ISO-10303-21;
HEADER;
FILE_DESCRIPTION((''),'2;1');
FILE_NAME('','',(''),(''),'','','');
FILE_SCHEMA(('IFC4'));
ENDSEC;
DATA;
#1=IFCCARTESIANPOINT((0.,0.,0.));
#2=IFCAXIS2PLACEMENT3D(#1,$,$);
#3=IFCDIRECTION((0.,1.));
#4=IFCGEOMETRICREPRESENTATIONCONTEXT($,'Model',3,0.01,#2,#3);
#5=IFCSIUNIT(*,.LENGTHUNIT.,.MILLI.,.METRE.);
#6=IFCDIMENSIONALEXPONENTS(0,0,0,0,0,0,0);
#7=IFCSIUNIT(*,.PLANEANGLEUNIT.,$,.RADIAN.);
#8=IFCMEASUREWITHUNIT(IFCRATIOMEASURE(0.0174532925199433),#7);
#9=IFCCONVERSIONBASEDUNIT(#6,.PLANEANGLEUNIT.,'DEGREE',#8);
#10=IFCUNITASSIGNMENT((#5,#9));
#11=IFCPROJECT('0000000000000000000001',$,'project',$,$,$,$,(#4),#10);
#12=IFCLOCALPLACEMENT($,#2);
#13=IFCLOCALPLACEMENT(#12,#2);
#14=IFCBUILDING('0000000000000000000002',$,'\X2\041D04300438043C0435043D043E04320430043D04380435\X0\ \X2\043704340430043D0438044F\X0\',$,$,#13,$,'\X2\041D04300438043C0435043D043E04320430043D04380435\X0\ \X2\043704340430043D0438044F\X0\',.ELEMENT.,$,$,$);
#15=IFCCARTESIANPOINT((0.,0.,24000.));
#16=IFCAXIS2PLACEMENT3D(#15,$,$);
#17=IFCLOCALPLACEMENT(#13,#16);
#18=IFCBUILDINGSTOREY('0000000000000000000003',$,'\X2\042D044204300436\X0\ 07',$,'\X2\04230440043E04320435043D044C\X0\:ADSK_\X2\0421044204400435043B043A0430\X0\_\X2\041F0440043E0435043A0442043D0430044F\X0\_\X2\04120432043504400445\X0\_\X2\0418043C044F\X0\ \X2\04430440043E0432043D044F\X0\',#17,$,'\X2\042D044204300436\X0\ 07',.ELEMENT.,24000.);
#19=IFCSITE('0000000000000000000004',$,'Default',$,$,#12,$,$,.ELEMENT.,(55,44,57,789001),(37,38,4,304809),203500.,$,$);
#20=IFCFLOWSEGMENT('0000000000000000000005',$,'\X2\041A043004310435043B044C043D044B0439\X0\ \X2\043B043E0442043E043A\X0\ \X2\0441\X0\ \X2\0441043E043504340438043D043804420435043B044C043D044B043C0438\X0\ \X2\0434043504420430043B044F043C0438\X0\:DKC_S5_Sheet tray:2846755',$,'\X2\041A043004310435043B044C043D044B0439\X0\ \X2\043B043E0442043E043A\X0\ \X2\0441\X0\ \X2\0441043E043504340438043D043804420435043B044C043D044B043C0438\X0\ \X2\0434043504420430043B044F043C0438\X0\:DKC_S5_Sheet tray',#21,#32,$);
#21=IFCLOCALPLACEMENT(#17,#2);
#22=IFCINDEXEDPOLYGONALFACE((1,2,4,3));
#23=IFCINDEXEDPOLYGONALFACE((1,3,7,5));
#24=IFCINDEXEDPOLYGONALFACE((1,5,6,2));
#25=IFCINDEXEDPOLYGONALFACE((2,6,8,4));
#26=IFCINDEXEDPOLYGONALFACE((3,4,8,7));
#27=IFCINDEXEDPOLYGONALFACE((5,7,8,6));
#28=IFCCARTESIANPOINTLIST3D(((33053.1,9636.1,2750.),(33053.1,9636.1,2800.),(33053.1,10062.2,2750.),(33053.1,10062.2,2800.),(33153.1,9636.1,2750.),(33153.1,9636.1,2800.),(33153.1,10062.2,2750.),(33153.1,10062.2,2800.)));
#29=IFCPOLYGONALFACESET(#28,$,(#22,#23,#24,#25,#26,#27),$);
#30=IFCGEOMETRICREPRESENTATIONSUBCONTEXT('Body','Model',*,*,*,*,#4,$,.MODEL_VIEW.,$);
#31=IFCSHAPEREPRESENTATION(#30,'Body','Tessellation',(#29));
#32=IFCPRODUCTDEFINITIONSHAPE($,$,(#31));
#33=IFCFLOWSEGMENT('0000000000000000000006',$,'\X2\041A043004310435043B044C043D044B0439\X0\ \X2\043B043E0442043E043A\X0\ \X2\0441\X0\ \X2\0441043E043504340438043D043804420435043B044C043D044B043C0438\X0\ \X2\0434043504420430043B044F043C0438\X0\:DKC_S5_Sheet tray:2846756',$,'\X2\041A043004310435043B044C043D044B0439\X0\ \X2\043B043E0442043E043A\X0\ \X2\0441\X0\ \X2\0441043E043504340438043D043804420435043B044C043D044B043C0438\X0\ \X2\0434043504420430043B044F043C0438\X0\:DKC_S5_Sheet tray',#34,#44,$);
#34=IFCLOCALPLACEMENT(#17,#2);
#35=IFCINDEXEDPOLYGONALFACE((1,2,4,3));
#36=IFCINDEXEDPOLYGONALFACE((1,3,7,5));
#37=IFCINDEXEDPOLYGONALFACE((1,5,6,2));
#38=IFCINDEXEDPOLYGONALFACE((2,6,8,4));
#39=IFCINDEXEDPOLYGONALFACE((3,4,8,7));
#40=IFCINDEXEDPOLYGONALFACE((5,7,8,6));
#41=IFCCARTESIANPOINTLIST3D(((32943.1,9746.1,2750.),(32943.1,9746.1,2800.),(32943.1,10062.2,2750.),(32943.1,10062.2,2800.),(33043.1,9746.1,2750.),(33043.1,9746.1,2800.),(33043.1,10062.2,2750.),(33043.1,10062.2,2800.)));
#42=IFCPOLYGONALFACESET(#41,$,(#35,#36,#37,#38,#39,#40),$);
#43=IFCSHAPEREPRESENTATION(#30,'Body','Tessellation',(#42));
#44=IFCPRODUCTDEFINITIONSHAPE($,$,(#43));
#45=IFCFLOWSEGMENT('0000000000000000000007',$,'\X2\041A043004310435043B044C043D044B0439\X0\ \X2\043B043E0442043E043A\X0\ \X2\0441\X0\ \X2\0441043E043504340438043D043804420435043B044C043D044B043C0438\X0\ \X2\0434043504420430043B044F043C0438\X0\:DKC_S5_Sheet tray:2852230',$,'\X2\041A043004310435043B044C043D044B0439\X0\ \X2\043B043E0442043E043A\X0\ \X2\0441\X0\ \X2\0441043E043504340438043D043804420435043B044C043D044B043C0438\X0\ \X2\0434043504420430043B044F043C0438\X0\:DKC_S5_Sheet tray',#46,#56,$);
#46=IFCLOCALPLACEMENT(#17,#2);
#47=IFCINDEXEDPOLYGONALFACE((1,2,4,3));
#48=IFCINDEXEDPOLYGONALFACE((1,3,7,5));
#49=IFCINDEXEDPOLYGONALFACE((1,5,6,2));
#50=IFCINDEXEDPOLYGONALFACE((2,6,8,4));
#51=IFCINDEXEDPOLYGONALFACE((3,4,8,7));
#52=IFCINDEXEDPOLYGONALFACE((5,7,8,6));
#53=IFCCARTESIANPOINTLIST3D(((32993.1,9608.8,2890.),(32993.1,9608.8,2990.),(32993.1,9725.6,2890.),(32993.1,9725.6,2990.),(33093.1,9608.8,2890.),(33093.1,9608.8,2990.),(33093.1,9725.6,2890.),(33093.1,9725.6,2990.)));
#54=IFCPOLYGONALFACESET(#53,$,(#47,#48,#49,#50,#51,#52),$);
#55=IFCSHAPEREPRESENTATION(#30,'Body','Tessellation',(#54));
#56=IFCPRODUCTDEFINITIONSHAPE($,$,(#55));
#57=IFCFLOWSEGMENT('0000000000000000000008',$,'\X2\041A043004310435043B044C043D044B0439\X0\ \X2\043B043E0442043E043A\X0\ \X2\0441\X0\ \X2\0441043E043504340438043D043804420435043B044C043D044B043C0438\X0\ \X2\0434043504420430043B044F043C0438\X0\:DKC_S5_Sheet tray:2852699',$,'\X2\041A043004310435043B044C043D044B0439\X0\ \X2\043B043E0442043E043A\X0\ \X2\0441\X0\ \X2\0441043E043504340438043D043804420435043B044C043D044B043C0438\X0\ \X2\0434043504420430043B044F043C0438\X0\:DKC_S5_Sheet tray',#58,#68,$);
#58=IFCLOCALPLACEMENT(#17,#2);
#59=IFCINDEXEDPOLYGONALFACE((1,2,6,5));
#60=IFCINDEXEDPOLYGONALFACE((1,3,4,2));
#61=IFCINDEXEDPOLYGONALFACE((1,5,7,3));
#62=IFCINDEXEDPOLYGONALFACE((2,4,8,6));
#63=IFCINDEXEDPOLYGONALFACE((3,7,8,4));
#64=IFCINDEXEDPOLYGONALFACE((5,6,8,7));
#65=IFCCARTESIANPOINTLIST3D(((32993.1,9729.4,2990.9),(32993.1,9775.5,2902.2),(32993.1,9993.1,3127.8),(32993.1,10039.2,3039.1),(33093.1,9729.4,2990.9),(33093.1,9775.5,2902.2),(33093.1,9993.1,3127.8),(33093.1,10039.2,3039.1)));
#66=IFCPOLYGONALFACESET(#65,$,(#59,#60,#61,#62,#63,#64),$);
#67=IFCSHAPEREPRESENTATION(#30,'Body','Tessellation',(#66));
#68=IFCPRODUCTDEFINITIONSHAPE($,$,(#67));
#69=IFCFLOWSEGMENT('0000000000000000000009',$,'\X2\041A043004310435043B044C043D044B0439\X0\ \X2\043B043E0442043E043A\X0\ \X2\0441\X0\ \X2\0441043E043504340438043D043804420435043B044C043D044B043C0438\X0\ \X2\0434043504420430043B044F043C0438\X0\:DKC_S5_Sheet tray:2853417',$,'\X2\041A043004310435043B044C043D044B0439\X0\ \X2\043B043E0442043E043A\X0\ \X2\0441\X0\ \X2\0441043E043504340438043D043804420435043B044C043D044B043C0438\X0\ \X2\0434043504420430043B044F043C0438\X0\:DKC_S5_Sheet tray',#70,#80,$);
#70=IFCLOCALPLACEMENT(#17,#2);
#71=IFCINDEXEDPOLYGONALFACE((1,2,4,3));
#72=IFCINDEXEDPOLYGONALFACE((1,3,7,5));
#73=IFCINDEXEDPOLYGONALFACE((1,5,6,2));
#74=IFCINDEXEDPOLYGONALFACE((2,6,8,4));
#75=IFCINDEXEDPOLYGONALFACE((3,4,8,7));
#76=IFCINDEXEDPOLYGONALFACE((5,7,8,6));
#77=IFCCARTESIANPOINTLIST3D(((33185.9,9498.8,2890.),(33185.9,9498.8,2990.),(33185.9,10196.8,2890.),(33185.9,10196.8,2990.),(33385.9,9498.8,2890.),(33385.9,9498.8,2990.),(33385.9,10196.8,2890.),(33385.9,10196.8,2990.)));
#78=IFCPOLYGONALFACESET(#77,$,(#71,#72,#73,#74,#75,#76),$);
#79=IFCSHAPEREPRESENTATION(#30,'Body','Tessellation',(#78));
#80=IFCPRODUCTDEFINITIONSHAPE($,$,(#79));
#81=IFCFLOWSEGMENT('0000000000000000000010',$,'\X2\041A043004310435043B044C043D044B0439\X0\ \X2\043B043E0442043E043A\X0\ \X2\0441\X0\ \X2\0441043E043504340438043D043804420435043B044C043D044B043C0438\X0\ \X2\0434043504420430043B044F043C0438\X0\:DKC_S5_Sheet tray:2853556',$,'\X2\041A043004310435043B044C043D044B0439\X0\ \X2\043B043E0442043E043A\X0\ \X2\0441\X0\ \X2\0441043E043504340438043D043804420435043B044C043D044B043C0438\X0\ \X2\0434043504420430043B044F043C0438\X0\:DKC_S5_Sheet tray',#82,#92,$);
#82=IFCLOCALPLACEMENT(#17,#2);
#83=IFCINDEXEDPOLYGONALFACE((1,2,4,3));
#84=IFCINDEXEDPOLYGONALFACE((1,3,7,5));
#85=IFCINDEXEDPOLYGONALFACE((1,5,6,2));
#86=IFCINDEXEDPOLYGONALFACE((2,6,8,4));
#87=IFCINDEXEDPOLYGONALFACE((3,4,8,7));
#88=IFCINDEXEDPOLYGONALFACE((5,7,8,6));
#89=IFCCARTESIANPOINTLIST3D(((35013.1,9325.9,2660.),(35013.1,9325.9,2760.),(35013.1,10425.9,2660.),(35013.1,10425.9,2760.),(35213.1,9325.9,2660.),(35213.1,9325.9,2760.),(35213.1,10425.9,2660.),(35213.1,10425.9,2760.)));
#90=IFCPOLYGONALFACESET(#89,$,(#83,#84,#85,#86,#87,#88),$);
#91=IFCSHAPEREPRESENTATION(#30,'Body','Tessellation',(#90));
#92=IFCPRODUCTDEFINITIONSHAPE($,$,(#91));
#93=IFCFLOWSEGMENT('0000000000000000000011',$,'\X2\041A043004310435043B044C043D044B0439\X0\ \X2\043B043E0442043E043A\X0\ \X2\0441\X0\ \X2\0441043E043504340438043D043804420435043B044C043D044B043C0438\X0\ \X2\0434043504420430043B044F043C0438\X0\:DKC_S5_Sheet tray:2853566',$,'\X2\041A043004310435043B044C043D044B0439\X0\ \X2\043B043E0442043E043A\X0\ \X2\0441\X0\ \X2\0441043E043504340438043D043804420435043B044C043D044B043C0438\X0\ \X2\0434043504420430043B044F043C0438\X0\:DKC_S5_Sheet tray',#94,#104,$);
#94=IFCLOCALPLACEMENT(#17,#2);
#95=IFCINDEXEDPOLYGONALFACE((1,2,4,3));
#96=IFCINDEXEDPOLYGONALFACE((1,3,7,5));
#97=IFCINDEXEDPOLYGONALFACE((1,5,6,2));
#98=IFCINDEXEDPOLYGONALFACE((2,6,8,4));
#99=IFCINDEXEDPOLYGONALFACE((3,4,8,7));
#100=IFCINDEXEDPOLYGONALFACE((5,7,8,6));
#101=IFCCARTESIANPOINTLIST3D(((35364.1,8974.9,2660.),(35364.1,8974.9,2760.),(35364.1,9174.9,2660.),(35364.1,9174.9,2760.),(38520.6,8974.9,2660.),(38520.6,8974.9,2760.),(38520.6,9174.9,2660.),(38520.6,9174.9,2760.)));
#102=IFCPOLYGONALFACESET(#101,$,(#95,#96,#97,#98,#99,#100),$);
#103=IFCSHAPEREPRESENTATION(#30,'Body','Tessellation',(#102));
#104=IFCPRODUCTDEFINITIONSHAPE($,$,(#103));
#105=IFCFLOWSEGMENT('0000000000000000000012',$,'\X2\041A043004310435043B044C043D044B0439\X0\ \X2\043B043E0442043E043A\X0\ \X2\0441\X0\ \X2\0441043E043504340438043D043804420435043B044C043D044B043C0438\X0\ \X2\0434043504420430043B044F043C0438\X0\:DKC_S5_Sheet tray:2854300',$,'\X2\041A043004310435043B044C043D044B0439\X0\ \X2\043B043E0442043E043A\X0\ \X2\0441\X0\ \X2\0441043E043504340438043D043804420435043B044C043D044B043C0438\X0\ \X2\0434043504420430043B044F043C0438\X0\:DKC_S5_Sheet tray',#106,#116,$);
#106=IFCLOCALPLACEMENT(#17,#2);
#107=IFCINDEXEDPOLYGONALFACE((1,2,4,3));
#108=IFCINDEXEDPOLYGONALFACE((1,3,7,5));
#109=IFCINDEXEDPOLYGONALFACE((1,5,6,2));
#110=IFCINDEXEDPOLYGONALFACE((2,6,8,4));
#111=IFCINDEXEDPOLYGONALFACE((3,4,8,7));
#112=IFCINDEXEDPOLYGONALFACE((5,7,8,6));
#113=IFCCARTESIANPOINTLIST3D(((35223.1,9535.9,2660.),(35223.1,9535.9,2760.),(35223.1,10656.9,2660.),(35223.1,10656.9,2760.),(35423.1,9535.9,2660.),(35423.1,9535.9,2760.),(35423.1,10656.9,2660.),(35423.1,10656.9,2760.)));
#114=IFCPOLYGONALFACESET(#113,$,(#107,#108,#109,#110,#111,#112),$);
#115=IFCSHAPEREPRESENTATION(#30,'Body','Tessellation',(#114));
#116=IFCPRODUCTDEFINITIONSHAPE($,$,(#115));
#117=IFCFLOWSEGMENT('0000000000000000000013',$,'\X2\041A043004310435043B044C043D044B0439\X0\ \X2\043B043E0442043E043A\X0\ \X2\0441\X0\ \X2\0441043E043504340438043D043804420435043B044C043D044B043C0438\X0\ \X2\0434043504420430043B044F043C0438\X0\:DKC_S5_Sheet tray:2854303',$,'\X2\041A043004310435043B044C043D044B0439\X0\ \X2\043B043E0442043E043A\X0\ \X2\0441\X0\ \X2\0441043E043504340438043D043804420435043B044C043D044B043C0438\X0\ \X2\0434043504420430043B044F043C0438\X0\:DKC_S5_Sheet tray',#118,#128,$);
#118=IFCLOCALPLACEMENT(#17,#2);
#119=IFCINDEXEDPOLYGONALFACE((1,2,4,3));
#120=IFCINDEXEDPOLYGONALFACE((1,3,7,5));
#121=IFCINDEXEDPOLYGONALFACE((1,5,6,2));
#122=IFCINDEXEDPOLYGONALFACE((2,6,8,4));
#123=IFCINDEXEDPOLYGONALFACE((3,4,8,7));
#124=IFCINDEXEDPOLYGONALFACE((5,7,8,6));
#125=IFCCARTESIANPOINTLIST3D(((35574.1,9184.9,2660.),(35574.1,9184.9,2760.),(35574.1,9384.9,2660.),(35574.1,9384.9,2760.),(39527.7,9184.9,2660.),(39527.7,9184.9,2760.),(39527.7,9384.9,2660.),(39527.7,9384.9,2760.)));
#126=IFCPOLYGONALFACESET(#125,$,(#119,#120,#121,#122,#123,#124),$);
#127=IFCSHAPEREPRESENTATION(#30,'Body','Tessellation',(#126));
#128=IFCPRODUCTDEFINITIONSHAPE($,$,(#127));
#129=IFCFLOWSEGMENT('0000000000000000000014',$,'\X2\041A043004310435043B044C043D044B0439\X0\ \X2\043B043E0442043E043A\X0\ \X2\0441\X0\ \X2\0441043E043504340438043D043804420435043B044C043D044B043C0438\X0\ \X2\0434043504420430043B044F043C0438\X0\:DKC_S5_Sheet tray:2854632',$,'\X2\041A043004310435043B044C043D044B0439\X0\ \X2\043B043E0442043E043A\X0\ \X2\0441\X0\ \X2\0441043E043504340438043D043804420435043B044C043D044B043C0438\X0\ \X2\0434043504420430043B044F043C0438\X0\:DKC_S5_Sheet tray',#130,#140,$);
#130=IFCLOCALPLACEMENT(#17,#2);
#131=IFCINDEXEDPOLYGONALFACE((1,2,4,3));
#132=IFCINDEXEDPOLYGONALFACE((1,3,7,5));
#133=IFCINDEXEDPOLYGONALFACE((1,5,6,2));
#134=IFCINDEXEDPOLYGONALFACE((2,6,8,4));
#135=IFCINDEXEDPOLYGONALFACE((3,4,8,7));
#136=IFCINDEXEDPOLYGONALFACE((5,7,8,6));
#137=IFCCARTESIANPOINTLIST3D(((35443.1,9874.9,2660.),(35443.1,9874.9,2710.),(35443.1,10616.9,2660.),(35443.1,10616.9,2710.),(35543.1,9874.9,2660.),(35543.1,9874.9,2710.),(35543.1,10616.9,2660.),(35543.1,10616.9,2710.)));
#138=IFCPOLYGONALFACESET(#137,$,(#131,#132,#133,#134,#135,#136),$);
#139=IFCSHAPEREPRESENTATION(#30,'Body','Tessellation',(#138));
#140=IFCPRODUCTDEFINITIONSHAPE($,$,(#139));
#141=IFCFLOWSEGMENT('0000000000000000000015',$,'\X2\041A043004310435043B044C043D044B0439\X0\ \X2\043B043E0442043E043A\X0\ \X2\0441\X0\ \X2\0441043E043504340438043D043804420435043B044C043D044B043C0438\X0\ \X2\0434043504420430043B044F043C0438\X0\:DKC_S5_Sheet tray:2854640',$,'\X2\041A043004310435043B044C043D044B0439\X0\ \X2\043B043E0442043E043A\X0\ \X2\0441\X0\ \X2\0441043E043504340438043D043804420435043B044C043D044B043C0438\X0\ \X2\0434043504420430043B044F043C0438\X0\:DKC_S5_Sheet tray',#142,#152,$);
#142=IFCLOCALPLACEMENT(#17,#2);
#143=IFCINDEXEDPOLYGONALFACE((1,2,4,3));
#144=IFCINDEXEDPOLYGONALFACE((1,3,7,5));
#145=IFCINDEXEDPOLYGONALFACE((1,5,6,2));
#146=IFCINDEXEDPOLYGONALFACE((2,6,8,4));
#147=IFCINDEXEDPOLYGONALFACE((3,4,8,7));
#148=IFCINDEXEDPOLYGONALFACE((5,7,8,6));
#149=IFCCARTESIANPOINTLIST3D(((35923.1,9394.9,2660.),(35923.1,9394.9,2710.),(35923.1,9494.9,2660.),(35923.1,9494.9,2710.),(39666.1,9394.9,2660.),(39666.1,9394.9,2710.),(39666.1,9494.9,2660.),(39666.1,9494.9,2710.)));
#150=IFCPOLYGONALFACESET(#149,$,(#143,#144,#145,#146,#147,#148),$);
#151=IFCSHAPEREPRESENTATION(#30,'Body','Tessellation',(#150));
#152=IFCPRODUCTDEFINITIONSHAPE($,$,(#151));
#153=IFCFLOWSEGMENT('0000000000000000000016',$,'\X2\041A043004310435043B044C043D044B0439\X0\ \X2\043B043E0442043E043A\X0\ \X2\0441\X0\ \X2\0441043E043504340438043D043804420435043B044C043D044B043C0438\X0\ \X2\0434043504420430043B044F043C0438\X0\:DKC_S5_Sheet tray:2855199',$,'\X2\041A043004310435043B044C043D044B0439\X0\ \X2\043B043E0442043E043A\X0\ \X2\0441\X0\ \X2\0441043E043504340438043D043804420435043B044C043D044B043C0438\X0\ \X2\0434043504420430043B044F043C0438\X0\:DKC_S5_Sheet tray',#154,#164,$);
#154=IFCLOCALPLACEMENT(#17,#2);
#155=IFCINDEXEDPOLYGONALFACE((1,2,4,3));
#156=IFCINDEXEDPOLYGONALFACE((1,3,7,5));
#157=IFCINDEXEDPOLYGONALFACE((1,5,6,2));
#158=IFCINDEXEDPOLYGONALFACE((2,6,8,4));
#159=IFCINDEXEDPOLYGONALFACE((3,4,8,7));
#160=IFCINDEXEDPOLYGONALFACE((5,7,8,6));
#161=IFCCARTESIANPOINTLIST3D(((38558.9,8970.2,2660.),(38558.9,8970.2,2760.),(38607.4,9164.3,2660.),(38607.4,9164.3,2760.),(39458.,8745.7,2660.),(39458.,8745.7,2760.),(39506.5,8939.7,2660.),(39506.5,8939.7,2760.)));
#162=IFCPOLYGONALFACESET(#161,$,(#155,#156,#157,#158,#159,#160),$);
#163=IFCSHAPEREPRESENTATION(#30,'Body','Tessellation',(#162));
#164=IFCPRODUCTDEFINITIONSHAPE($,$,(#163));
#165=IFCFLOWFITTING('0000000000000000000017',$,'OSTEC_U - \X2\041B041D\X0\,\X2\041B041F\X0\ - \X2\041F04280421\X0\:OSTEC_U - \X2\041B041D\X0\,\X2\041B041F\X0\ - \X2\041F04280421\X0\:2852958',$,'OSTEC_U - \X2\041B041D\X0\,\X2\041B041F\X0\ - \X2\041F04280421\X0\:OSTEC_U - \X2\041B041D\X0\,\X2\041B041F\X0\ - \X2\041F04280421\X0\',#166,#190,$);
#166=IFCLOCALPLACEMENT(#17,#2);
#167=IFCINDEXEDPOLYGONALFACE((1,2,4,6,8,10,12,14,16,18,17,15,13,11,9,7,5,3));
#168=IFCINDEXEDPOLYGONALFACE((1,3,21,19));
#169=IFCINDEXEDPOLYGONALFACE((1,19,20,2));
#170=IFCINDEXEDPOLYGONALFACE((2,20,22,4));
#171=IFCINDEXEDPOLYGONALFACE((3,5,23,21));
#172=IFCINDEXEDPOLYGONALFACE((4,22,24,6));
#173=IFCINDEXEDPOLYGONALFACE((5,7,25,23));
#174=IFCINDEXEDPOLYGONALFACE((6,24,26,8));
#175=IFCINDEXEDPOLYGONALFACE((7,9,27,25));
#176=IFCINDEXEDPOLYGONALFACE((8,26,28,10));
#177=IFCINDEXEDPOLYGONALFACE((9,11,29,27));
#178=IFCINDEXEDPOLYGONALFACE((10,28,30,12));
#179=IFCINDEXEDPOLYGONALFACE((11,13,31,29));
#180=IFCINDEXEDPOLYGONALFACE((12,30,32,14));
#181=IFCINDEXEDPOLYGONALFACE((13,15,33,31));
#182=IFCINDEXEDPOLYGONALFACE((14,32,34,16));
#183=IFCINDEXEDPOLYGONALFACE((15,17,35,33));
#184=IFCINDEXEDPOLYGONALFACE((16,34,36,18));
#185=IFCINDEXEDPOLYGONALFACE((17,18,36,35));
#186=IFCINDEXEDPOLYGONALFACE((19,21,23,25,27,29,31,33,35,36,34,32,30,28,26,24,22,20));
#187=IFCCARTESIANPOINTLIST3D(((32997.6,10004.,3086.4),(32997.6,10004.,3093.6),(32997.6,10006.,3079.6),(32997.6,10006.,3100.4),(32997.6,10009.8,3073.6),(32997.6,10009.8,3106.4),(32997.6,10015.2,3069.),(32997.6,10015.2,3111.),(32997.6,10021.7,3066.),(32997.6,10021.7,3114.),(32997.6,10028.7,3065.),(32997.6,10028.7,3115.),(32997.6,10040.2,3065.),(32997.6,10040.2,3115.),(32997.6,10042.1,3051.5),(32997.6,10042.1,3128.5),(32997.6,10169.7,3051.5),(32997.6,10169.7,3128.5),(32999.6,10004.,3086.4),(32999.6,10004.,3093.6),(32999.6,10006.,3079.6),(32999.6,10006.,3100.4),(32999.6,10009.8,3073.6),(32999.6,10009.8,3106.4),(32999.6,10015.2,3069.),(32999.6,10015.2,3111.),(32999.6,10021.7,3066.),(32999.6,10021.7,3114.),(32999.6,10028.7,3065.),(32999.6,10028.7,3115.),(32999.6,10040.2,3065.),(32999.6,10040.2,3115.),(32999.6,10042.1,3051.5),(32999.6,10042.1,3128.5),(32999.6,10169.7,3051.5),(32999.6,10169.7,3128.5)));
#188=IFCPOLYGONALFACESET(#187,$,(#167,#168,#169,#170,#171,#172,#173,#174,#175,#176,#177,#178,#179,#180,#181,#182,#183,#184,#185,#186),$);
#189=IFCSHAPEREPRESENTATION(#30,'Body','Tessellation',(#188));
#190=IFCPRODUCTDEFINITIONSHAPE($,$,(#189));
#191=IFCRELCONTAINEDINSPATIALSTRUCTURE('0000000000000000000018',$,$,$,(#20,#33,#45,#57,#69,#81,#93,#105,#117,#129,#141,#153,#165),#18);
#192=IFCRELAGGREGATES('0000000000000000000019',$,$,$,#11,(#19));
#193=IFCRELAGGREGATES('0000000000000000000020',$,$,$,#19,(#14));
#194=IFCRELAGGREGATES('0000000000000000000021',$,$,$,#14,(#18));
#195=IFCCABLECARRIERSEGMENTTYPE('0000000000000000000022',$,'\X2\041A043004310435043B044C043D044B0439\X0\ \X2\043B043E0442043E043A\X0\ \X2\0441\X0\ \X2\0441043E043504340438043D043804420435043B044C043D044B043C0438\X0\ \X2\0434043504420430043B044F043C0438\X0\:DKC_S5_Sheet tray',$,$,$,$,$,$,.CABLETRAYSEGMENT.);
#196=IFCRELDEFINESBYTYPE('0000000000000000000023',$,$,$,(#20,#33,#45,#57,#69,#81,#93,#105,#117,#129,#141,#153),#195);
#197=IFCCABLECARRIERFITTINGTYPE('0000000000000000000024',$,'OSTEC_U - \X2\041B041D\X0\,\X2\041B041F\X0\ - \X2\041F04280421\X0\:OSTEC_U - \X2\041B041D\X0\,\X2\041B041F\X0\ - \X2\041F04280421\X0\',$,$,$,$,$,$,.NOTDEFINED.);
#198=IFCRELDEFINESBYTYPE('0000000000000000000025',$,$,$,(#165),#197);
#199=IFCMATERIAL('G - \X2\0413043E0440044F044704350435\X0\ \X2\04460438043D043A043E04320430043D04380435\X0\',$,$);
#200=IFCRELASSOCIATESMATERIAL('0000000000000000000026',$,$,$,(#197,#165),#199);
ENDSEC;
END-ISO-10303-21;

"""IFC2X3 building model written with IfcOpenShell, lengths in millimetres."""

from ifc_helpers import new_model, entity, si_unit, converted_unit, direction, frame, frame_2d, origin, origin_2d_with_axis, place, context, subcontext, project, spatial, polyline, circle_curve, parameter, trimmed, segment, composite_curve, rectangle, outline, extrude, source, transform, mapped, material, type_object, type_shapes, element, save


model = new_model("IFC2X3")

# Units and contexts
model_context = context("Model", 3, precision=0.01, world=origin(), true_north=direction((0.0, 1.0)))
body_context = subcontext(model_context, "Body", "Model", "MODEL_VIEW")
ifc_project = project(units=[si_unit("LENGTHUNIT", "METRE", prefix="MILLI"), converted_unit("PLANEANGLEUNIT", "DEGREE", entity("IfcRatioMeasure", 0.0174532925199433), si_unit("PLANEANGLEUNIT", "RADIAN"), dimensions=[0, 0, 0, 0, 0, 0, 0])], contexts=[model_context])

# Site, building, storey
site_placement = place(None, origin())
site = spatial("IfcSite", under=ifc_project, at=site_placement, Name="Default", CompositionType="ELEMENT", RefLatitude=(55, 44, 57, 789001), RefLongitude=(37, 38, 4, 304809), RefElevation=203500.0)
building_placement = place(site_placement, origin())
building = spatial("IfcBuilding", under=site, at=building_placement, Name="Наименование здания", LongName="Наименование здания", CompositionType="ELEMENT")
storey_placement = place(building_placement, frame((0.0, 0.0, 24000.0)))
storey = spatial("IfcBuildingStorey", under=building, at=storey_placement, Name="Этаж 07", ObjectType="Уровень:ADSK_Стрелка_Проектная_Вверх_Имя уровня", LongName="Этаж 07", CompositionType="ELEMENT", Elevation=24000.0)

# Flow segments
cable_carrier_segment_type = type_object("IfcCableCarrierSegmentType", Name="Кабельный лоток с соединительными деталями:DKC_S5_Sheet tray", PredefinedType="CABLETRAYSEGMENT")
flow_segment_1_placement = place(storey_placement, frame((33053.1, 9636.1, 2750.0)))
element("IfcFlowSegment", 1, at=flow_segment_1_placement, inside=storey, type_object=cable_carrier_segment_type, Name="Кабельный лоток с соединительными деталями:DKC_S5_Sheet tray:2846755", ObjectType="Кабельный лоток с соединительными деталями:DKC_S5_Sheet tray", context=body_context, shape_type="SweptSolid", body=[
    extrude(rectangle(XDim=426.1, YDim=100.0, at=origin_2d_with_axis()), frame((50.0, 213.0, 0.0), z_axis=(0.0, 0.0, 1.0), x_axis=(0.0, -1.0, 0.0)), (0.0, 0.0, 1.0), 50.0),
])
flow_segment_2_placement = place(storey_placement, frame((32943.1, 9746.1, 2750.0)))
element("IfcFlowSegment", 2, at=flow_segment_2_placement, inside=storey, type_object=cable_carrier_segment_type, Name="Кабельный лоток с соединительными деталями:DKC_S5_Sheet tray:2846756", ObjectType="Кабельный лоток с соединительными деталями:DKC_S5_Sheet tray", context=body_context, shape_type="SweptSolid", body=[
    extrude(rectangle(XDim=316.1, YDim=100.0, at=origin_2d_with_axis()), frame((50.0, 158.0, 0.0), z_axis=(0.0, 0.0, 1.0), x_axis=(0.0, 1.0, 0.0)), (0.0, 0.0, 1.0), 50.0),
])
flow_segment_3_placement = place(storey_placement, frame((32993.1, 9608.8, 2890.0)))
element("IfcFlowSegment", 3, at=flow_segment_3_placement, inside=storey, type_object=cable_carrier_segment_type, Name="Кабельный лоток с соединительными деталями:DKC_S5_Sheet tray:2852230", ObjectType="Кабельный лоток с соединительными деталями:DKC_S5_Sheet tray", context=body_context, shape_type="SweptSolid", body=[
    extrude(rectangle(XDim=116.8, YDim=100.0, at=origin_2d_with_axis()), frame((50.0, 58.4, 0.0), z_axis=(0.0, 0.0, 1.0), x_axis=(0.0, 1.0, 0.0)), (0.0, 0.0, 1.0), 100.0),
])
flow_segment_4_placement = place(storey_placement, frame((32993.1, 9729.4, 2902.2)))
element("IfcFlowSegment", 4, at=flow_segment_4_placement, inside=storey, type_object=cable_carrier_segment_type, Name="Кабельный лоток с соединительными деталями:DKC_S5_Sheet tray:2852699", ObjectType="Кабельный лоток с соединительными деталями:DKC_S5_Sheet tray", context=body_context, shape_type="SweptSolid", body=[
    extrude(rectangle(XDim=100.0, YDim=100.0, at=origin_2d_with_axis()), frame((50.0, 23.0, 44.4), z_axis=(0.0, 0.887491, 0.460826), x_axis=(0.0, -0.460826, 0.887491)), (0.0, 0.0, 1.0), 297.1),
])
flow_segment_5_placement = place(storey_placement, frame((33185.9, 9498.8, 2890.0)))
element("IfcFlowSegment", 5, at=flow_segment_5_placement, inside=storey, type_object=cable_carrier_segment_type, Name="Кабельный лоток с соединительными деталями:DKC_S5_Sheet tray:2853417", ObjectType="Кабельный лоток с соединительными деталями:DKC_S5_Sheet tray", context=body_context, shape_type="SweptSolid", body=[
    extrude(rectangle(XDim=698.0, YDim=200.0, at=origin_2d_with_axis()), frame((100.0, 349.0, 0.0), z_axis=(0.0, 0.0, 1.0), x_axis=(0.0, 1.0, 0.0)), (0.0, 0.0, 1.0), 100.0),
])
flow_segment_6_placement = place(storey_placement, frame((35013.1, 9325.9, 2660.0)))
element("IfcFlowSegment", 6, at=flow_segment_6_placement, inside=storey, type_object=cable_carrier_segment_type, Name="Кабельный лоток с соединительными деталями:DKC_S5_Sheet tray:2853556", ObjectType="Кабельный лоток с соединительными деталями:DKC_S5_Sheet tray", context=body_context, shape_type="SweptSolid", body=[
    extrude(rectangle(XDim=1100.0, YDim=200.0, at=origin_2d_with_axis()), frame((100.0, 550.0, 0.0), z_axis=(0.0, 0.0, 1.0), x_axis=(0.0, -1.0, 0.0)), (0.0, 0.0, 1.0), 100.0),
])
flow_segment_7_placement = place(storey_placement, frame((35364.1, 8974.9, 2660.0)))
element("IfcFlowSegment", 7, at=flow_segment_7_placement, inside=storey, type_object=cable_carrier_segment_type, Name="Кабельный лоток с соединительными деталями:DKC_S5_Sheet tray:2853566", ObjectType="Кабельный лоток с соединительными деталями:DKC_S5_Sheet tray", context=body_context, shape_type="SweptSolid", body=[
    extrude(rectangle(XDim=3156.5, YDim=200.0, at=origin_2d_with_axis()), frame((1578.3, 100.0, 0.0)), (0.0, 0.0, 1.0), 100.0),
])
flow_segment_8_placement = place(storey_placement, frame((35223.1, 9535.9, 2660.0)))
element("IfcFlowSegment", 8, at=flow_segment_8_placement, inside=storey, type_object=cable_carrier_segment_type, Name="Кабельный лоток с соединительными деталями:DKC_S5_Sheet tray:2854300", ObjectType="Кабельный лоток с соединительными деталями:DKC_S5_Sheet tray", context=body_context, shape_type="SweptSolid", body=[
    extrude(rectangle(XDim=1121.0, YDim=200.0, at=origin_2d_with_axis()), frame((100.0, 560.5, 0.0), z_axis=(0.0, 0.0, 1.0), x_axis=(0.0, -1.0, 0.0)), (0.0, 0.0, 1.0), 100.0),
])
flow_segment_9_placement = place(storey_placement, frame((35574.1, 9184.9, 2660.0)))
element("IfcFlowSegment", 9, at=flow_segment_9_placement, inside=storey, type_object=cable_carrier_segment_type, Name="Кабельный лоток с соединительными деталями:DKC_S5_Sheet tray:2854303", ObjectType="Кабельный лоток с соединительными деталями:DKC_S5_Sheet tray", context=body_context, shape_type="SweptSolid", body=[
    extrude(rectangle(XDim=3953.6, YDim=200.0, at=origin_2d_with_axis()), frame((1976.8, 100.0, 0.0)), (0.0, 0.0, 1.0), 100.0),
])
flow_segment_10_placement = place(storey_placement, frame((35443.1, 9874.9, 2660.0)))
element("IfcFlowSegment", 10, at=flow_segment_10_placement, inside=storey, type_object=cable_carrier_segment_type, Name="Кабельный лоток с соединительными деталями:DKC_S5_Sheet tray:2854632", ObjectType="Кабельный лоток с соединительными деталями:DKC_S5_Sheet tray", context=body_context, shape_type="SweptSolid", body=[
    extrude(rectangle(XDim=742.0, YDim=100.0, at=origin_2d_with_axis()), frame((50.0, 371.0, 0.0), z_axis=(0.0, 0.0, 1.0), x_axis=(0.0, -1.0, 0.0)), (0.0, 0.0, 1.0), 50.0),
])
flow_segment_11_placement = place(storey_placement, frame((35923.1, 9394.9, 2660.0)))
element("IfcFlowSegment", 11, at=flow_segment_11_placement, inside=storey, type_object=cable_carrier_segment_type, Name="Кабельный лоток с соединительными деталями:DKC_S5_Sheet tray:2854640", ObjectType="Кабельный лоток с соединительными деталями:DKC_S5_Sheet tray", context=body_context, shape_type="SweptSolid", body=[
    extrude(rectangle(XDim=3743.0, YDim=100.0, at=origin_2d_with_axis()), frame((1871.5, 50.0, 0.0)), (0.0, 0.0, 1.0), 50.0),
])
flow_segment_12_placement = place(storey_placement, frame((38558.9, 8745.7, 2660.0)))
element("IfcFlowSegment", 12, at=flow_segment_12_placement, inside=storey, type_object=cable_carrier_segment_type, Name="Кабельный лоток с соединительными деталями:DKC_S5_Sheet tray:2855199", ObjectType="Кабельный лоток с соединительными деталями:DKC_S5_Sheet tray", context=body_context, shape_type="SweptSolid", body=[
    extrude(rectangle(XDim=926.7, YDim=200.0, at=origin_2d_with_axis()), frame((473.8, 209.3, 0.0), z_axis=(0.0, 0.0, 1.0), x_axis=(-0.970197, 0.242319, 0.0)), (0.0, 0.0, 1.0), 100.0),
])

# Flow fitting
ifc_material_1 = material(Name="G - Горячее цинкование")
cable_carrier_fitting_type_1 = type_object("IfcCableCarrierFittingType", Name="OSTEC_U - ЛН,ЛП - ПШС:OSTEC_U - ЛН,ЛП - ПШС", PredefinedType="NOTDEFINED", material=ifc_material_1)
shared_shape_1 = source(origin(), body_context, "Body", "SweptSolid", [
    extrude(outline(composite_curve([segment(trimmed(circle_curve(frame_2d((-41.5, 0.0), x_axis=(1.0, 0.0)), 25.0), [parameter(90.0)], [parameter(270.0)], True, "PARAMETER"), True, "CONTINUOUS"), segment(polyline([(-41.5, -25.0), (-30.0, -25.0)]), True, "CONTINUOUS"), segment(polyline([(-30.0, -25.0), (-28.1, -38.5)]), True, "CONTINUOUS"), segment(polyline([(-28.1, -38.5), (99.5, -38.5)]), True, "CONTINUOUS"), segment(polyline([(99.5, -38.5), (99.5, 38.5)]), True, "CONTINUOUS"), segment(polyline([(99.5, 38.5), (-28.1, 38.5)]), True, "CONTINUOUS"), segment(polyline([(-28.1, 38.5), (-30.0, 25.0)]), True, "CONTINUOUS"), segment(polyline([(-30.0, 25.0), (-41.5, 25.0)]), True, "CONTINUOUS")], self_intersect=False)), frame((41.5, 0.0, 0.0), z_axis=(0.0, 0.0, -1.0), x_axis=(1.0, 0.0, 0.0)), (0.0, 0.0, -1.0), 2.0),
])
type_shapes(cable_carrier_fitting_type_1, [shared_shape_1])
flow_fitting_1_placement = place(storey_placement, frame((32999.6, 10028.7, 3090.0), z_axis=(-1.0, 0.0, 0.0), x_axis=(0.0, 1.0, 0.0)))
element("IfcFlowFitting", 13, at=flow_fitting_1_placement, inside=storey, type_object=cable_carrier_fitting_type_1, material=ifc_material_1, Name="OSTEC_U - ЛН,ЛП - ПШС:OSTEC_U - ЛН,ЛП - ПШС:2852958", ObjectType="OSTEC_U - ЛН,ЛП - ПШС:OSTEC_U - ЛН,ЛП - ПШС", context=body_context, shape_type="MappedRepresentation", body=[
    mapped(shared_shape_1, transform((0.0, 0.0, 0.0), scale=1.0)),
])

save(model, "model.ifc")
